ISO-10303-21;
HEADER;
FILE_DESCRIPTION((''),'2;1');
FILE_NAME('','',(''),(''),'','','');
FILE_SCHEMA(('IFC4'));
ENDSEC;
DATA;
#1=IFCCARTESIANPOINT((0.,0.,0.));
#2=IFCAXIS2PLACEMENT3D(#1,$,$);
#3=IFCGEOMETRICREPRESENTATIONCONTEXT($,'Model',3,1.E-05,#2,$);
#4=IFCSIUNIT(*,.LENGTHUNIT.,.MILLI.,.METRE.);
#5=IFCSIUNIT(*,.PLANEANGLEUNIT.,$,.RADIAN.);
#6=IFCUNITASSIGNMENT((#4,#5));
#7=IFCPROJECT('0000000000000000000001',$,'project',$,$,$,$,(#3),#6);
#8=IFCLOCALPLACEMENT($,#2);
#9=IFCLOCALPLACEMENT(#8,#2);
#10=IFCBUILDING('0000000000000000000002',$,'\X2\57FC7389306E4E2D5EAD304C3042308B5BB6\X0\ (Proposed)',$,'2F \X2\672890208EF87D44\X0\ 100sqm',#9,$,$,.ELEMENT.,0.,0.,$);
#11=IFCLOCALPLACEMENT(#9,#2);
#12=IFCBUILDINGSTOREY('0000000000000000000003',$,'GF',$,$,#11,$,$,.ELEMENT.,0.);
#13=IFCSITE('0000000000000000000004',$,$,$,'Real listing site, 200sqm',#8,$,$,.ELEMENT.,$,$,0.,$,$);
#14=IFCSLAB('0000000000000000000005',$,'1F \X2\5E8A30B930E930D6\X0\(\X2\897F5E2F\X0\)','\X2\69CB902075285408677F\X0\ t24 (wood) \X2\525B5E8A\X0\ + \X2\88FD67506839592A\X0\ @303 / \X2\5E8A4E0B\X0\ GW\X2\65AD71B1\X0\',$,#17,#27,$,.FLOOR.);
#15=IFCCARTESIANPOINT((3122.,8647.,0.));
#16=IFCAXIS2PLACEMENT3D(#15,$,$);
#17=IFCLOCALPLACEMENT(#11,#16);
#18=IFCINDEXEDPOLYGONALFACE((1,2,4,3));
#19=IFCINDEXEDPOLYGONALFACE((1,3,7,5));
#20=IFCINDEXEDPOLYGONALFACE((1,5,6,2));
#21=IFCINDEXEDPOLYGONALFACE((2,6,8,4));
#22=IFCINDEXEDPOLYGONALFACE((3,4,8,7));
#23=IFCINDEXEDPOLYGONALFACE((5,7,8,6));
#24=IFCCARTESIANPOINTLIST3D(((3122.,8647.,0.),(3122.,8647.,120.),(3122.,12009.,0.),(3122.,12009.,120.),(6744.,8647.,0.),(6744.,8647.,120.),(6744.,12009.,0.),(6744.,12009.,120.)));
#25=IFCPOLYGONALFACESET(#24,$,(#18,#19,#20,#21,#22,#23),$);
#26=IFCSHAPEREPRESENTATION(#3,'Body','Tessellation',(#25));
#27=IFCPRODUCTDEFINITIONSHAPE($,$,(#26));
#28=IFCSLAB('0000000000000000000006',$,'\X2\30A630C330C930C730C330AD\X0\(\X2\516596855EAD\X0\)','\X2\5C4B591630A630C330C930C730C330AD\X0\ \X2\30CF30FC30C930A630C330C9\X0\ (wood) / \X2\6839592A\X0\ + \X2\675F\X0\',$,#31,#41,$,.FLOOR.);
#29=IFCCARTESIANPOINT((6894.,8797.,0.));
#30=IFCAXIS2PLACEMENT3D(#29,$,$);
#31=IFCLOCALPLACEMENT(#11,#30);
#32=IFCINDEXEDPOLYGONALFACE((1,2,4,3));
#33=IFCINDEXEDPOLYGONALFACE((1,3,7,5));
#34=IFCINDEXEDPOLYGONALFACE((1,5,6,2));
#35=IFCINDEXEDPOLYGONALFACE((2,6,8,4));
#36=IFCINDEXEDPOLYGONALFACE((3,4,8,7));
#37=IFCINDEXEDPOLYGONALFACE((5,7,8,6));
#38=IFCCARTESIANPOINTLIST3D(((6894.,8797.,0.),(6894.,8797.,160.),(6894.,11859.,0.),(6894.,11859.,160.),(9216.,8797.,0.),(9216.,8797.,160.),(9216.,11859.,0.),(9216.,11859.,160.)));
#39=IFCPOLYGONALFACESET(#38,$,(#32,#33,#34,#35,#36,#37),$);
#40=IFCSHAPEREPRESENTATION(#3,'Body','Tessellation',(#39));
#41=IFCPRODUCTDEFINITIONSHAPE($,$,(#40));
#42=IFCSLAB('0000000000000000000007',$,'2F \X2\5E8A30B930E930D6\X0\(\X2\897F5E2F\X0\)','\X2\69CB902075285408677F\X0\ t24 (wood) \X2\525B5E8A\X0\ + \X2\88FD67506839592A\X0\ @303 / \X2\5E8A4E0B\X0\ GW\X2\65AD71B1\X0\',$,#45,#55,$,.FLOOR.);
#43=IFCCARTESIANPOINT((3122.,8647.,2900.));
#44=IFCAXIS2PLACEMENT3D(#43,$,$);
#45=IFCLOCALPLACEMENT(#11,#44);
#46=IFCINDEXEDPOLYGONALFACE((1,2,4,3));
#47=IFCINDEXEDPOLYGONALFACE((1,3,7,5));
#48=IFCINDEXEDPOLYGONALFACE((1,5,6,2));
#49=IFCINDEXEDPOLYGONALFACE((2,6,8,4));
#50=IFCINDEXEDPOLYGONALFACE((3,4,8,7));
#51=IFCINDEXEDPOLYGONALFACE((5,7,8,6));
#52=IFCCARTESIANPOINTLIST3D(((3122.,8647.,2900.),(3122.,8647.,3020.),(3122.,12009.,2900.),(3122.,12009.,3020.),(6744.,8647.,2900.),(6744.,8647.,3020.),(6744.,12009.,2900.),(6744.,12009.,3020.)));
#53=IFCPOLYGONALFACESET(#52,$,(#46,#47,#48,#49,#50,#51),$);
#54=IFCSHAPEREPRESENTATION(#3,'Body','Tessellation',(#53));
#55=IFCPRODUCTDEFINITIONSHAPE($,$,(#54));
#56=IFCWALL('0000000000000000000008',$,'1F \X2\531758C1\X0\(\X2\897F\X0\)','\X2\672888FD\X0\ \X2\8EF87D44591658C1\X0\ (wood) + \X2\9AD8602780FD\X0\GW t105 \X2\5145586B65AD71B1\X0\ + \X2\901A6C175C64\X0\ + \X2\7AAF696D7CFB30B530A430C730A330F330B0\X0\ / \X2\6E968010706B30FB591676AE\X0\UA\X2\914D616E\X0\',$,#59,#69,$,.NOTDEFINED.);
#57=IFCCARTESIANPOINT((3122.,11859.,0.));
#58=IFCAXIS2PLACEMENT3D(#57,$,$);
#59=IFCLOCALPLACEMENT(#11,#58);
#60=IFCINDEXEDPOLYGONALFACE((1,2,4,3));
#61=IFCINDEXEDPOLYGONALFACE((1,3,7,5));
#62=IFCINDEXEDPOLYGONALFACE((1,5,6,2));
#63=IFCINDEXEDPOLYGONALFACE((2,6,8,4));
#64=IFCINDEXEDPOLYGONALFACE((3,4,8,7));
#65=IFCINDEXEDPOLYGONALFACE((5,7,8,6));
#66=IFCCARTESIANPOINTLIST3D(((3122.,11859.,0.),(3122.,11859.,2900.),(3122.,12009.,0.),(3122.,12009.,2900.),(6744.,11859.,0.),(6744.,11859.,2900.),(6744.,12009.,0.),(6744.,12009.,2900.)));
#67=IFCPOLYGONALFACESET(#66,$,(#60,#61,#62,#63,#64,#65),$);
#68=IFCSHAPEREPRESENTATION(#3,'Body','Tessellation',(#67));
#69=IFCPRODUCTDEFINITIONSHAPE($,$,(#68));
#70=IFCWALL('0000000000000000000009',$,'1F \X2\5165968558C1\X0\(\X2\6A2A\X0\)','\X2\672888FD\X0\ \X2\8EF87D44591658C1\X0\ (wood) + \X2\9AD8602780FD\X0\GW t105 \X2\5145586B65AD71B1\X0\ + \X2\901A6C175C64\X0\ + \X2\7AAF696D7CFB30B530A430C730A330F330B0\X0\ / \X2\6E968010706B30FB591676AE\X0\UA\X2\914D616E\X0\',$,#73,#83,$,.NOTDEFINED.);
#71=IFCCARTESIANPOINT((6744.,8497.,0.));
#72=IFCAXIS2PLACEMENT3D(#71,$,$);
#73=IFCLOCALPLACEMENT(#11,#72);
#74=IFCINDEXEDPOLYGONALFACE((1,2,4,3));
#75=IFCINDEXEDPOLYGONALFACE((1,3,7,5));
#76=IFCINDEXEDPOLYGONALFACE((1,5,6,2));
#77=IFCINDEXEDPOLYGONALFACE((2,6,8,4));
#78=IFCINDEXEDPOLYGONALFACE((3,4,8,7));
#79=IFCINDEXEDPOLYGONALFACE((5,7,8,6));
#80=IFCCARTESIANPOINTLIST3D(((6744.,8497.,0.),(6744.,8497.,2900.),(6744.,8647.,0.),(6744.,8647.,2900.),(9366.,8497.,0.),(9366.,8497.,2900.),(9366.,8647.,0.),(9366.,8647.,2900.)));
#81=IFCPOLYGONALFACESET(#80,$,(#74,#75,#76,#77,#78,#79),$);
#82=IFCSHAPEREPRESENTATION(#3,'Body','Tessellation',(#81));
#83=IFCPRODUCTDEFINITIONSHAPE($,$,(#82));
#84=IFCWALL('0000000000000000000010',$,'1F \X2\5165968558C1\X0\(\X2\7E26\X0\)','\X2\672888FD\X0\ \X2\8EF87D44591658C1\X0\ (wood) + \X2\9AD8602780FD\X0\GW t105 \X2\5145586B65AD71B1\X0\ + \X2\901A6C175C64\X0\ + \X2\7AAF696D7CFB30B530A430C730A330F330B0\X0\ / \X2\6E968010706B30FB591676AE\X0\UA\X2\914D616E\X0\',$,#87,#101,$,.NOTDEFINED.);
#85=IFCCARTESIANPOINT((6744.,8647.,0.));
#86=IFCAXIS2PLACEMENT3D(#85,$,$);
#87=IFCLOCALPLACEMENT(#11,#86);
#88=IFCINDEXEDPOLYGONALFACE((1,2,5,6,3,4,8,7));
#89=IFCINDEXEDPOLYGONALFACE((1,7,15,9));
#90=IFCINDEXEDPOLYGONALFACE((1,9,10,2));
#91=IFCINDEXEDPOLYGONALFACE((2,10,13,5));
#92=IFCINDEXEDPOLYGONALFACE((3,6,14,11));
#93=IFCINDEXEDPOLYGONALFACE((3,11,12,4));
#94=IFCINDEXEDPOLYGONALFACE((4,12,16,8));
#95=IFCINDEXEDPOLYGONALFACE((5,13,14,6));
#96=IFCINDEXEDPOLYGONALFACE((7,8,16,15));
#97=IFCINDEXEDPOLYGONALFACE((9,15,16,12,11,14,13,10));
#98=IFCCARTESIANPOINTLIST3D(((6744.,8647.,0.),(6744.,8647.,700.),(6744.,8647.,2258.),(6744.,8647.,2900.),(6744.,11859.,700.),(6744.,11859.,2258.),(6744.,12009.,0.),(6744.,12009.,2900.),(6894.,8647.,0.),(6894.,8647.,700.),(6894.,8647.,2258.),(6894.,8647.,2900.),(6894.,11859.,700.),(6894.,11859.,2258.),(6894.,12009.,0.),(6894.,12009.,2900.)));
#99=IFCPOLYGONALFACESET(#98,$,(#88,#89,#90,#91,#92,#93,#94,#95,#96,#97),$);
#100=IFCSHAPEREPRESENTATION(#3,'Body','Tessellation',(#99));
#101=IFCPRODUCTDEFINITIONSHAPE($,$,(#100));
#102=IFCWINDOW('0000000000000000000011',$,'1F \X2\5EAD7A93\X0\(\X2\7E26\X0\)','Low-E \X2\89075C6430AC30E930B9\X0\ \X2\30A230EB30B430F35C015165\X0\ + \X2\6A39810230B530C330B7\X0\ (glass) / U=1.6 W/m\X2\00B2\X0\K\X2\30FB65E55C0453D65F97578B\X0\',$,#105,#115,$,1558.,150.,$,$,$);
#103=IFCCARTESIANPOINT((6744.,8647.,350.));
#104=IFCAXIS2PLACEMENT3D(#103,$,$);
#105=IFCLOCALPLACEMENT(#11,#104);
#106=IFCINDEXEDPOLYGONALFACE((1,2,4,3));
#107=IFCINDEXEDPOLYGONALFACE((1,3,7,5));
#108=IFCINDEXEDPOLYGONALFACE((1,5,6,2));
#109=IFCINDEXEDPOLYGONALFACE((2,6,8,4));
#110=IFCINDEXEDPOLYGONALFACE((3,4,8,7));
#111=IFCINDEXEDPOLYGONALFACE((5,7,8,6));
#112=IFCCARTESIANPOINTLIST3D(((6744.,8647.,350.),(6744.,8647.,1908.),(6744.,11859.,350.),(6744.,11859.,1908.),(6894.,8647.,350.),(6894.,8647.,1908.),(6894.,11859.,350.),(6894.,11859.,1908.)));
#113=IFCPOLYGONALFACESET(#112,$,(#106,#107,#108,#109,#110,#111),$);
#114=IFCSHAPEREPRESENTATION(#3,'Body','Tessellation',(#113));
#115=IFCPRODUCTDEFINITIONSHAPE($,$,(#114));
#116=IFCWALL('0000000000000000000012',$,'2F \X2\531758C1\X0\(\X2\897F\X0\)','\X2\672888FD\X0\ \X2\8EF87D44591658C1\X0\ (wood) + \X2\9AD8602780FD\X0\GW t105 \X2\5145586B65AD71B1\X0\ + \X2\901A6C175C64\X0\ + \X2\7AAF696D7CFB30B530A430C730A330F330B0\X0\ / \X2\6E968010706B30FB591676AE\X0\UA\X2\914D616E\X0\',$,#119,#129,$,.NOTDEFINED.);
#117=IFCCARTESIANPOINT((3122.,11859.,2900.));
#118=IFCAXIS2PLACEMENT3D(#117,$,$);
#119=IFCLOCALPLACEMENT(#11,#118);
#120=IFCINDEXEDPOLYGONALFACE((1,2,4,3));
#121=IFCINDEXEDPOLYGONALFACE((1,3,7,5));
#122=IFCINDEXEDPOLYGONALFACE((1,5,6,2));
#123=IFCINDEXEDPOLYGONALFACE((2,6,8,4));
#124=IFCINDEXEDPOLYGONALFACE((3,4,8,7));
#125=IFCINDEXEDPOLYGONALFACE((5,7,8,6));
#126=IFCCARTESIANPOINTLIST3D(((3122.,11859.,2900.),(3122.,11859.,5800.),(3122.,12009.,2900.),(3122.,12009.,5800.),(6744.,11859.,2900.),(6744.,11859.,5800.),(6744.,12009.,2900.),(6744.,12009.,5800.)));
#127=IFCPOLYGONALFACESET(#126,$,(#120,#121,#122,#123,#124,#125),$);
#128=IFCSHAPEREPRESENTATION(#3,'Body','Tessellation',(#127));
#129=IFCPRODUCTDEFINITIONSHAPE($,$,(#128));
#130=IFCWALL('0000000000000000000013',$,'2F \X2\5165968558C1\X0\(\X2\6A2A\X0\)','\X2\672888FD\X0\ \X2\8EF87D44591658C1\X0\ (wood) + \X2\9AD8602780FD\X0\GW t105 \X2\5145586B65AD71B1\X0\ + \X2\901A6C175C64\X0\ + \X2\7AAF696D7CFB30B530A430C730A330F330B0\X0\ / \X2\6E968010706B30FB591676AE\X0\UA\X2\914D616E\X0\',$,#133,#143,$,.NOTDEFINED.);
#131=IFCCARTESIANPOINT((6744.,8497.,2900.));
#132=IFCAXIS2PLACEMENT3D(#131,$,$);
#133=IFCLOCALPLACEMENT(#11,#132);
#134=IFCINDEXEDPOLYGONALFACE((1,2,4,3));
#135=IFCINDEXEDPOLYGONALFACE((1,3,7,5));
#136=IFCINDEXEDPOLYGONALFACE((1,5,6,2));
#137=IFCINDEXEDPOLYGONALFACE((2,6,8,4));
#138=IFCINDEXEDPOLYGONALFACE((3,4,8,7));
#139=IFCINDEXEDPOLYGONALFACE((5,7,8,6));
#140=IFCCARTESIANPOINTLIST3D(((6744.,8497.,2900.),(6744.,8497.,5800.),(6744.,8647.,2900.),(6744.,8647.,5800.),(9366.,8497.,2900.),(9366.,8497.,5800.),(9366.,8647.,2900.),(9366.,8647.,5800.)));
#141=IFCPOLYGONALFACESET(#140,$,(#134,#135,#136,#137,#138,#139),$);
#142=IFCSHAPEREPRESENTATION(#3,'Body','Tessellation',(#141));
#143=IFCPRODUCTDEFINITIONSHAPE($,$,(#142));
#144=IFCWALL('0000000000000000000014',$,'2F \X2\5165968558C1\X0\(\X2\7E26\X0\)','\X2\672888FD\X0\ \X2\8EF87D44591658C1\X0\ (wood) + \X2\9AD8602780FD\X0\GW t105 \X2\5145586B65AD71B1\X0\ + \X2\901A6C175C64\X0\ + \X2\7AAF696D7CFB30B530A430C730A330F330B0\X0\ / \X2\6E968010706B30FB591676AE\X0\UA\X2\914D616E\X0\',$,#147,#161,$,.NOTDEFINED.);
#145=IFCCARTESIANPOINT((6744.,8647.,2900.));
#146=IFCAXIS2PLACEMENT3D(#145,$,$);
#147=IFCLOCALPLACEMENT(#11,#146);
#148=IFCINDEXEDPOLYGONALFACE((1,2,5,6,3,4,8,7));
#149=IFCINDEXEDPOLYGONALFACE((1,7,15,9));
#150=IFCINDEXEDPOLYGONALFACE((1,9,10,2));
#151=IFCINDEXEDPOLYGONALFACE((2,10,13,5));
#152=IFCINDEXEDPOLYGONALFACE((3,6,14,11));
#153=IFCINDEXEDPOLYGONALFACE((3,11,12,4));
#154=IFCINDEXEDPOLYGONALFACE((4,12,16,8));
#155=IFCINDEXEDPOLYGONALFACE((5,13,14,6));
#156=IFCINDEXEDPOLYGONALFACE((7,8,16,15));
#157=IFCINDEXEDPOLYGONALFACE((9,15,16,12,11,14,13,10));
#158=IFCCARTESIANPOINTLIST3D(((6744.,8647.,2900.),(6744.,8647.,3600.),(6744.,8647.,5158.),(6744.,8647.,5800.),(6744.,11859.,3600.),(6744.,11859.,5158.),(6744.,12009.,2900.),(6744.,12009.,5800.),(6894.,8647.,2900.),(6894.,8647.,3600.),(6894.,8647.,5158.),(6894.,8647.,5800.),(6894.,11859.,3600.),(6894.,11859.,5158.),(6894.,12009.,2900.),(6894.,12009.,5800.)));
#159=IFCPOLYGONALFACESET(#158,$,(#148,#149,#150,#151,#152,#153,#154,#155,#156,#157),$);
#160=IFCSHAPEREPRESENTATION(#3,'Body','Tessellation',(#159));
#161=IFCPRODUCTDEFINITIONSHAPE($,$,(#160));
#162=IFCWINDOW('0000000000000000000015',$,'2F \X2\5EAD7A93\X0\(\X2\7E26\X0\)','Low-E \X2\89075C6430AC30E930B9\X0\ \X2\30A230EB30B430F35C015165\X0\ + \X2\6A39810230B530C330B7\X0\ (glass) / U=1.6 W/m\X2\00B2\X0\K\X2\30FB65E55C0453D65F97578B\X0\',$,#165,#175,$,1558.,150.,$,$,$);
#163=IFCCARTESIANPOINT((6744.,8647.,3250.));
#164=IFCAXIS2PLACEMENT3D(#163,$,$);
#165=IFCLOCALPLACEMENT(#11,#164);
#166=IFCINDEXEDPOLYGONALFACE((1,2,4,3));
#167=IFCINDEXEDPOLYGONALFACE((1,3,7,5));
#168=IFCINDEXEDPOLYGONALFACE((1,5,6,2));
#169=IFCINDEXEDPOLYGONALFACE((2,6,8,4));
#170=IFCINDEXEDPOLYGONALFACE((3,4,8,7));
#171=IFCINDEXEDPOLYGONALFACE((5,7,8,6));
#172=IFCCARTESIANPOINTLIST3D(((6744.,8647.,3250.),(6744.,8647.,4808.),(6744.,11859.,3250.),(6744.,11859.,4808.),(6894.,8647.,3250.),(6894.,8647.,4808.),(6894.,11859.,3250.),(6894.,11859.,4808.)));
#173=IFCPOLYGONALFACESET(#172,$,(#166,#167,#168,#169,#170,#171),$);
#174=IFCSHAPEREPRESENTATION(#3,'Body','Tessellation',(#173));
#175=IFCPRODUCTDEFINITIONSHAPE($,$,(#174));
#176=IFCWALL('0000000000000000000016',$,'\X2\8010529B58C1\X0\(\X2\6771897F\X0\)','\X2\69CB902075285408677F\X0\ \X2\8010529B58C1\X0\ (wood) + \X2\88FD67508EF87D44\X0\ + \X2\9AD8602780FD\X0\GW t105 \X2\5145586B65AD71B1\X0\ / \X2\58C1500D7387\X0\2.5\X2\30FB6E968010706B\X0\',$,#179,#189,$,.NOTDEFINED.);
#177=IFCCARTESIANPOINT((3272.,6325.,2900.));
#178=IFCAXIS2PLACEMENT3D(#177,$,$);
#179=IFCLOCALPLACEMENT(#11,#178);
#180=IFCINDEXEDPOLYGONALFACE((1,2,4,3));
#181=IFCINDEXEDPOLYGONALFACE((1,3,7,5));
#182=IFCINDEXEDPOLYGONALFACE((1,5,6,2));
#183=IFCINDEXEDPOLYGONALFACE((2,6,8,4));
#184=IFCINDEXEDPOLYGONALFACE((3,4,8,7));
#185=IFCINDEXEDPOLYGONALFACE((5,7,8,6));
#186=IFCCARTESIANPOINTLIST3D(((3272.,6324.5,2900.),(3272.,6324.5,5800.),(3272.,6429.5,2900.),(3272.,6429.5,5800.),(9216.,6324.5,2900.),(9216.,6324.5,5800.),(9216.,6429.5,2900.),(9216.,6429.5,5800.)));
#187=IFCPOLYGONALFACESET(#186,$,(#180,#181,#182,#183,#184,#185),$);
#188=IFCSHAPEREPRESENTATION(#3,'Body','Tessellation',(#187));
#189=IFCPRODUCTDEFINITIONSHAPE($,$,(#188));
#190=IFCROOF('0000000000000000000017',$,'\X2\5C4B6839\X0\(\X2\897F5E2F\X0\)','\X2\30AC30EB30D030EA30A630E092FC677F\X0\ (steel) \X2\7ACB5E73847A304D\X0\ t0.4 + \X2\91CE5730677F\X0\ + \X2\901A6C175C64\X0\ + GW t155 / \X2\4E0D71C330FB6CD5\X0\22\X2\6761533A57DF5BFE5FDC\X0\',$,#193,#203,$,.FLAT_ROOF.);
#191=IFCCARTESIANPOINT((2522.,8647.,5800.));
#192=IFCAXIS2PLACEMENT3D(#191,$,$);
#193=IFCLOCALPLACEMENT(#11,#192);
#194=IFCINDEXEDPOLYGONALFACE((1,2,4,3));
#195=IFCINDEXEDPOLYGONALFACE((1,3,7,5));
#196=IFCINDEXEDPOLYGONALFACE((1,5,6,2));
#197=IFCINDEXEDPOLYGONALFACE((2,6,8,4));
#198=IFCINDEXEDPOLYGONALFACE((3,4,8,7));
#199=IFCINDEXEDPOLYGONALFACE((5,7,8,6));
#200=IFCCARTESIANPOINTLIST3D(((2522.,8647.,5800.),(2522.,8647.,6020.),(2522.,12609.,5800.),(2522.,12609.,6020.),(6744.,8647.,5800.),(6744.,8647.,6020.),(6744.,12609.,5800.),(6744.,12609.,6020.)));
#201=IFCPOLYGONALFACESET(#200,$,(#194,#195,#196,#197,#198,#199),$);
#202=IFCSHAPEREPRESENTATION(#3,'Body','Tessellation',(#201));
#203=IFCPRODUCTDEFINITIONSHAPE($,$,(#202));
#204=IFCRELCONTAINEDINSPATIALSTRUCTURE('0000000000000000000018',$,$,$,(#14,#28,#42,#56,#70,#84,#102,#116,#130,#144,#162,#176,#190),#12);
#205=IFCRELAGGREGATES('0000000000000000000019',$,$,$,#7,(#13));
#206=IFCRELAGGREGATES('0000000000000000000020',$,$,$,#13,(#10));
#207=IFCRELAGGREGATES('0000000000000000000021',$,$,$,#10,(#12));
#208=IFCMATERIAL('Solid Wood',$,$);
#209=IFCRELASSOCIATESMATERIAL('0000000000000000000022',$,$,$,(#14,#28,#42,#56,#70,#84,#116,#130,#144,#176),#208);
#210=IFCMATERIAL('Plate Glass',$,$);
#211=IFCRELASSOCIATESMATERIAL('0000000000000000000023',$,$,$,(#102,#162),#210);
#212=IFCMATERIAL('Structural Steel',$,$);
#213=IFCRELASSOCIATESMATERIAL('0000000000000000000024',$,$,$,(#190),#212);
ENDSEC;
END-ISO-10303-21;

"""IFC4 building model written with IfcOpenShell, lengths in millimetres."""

from ifc_helpers import new_model, si_unit, frame, frame_2d, origin, place, context, project, spatial, rectangle, extrude, material, element, fill, save


model = new_model("IFC4")

# Units and contexts
model_context = context("Model", 3, precision=1e-05, world=origin())
ifc_project = project(units=[si_unit("LENGTHUNIT", "METRE", prefix="MILLI"), si_unit("PLANEANGLEUNIT", "RADIAN")], contexts=[model_context])

# Site, building, storey
site_placement = place(None, origin())
site = spatial("IfcSite", under=ifc_project, at=site_placement, ObjectType="Real listing site, 200sqm", CompositionType="ELEMENT", RefElevation=0.0)
building_placement = place(site_placement, origin())
building = spatial("IfcBuilding", under=site, at=building_placement, Name="埼玉の中庭がある家 (Proposed)", ObjectType="2F 木造軸組 100sqm", CompositionType="ELEMENT", ElevationOfRefHeight=0.0, ElevationOfTerrain=0.0)
storey_placement = place(building_placement, origin())
storey = spatial("IfcBuildingStorey", under=building, at=storey_placement, Name="GF", CompositionType="ELEMENT", Elevation=0.0)

# Slabs
ifc_material_1 = material(Name="Solid Wood")
slab_1_placement = place(storey_placement, frame((3122.0, 8647.0, 0.0)))
element("IfcSlab", 1, at=slab_1_placement, inside=storey, material=ifc_material_1, Name="1F 床スラブ(西帯)", Description="構造用合板 t24 (wood) 剛床 + 製材根太 @303 / 床下 GW断熱", PredefinedType="FLOOR", context=model_context, shape_type="SweptSolid", body=[
    extrude(rectangle(XDim=3622.0, YDim=3362.0, at=frame_2d((1811.0, 1681.0))), frame((3122.0, 8647.0, 0.0)), (0.0, 0.0, 1.0), 120.0),
])
slab_2_placement = place(storey_placement, frame((6894.0, 8797.0, 0.0)))
element("IfcSlab", 2, at=slab_2_placement, inside=storey, material=ifc_material_1, Name="ウッドデッキ(入隅庭)", Description="屋外ウッドデッキ ハードウッド (wood) / 根太 + 束", PredefinedType="FLOOR", context=model_context, shape_type="SweptSolid", body=[
    extrude(rectangle(XDim=2322.0, YDim=3062.0, at=frame_2d((1161.0, 1531.0))), frame((6894.0, 8797.0, 0.0)), (0.0, 0.0, 1.0), 160.0),
])
slab_3_placement = place(storey_placement, frame((3122.0, 8647.0, 2900.0)))
element("IfcSlab", 3, at=slab_3_placement, inside=storey, material=ifc_material_1, Name="2F 床スラブ(西帯)", Description="構造用合板 t24 (wood) 剛床 + 製材根太 @303 / 床下 GW断熱", PredefinedType="FLOOR", context=model_context, shape_type="SweptSolid", body=[
    extrude(rectangle(XDim=3622.0, YDim=3362.0, at=frame_2d((1811.0, 1681.0))), frame((3122.0, 8647.0, 2900.0)), (0.0, 0.0, 1.0), 120.0),
])

# Walls
wall_1_placement = place(storey_placement, frame((3122.0, 11859.0, 0.0)))
element("IfcWall", 4, at=wall_1_placement, inside=storey, material=ifc_material_1, Name="1F 北壁(西)", Description="木製 軸組外壁 (wood) + 高性能GW t105 充填断熱 + 通気層 + 窯業系サイディング / 準耐火・外皮UA配慮", PredefinedType="NOTDEFINED", context=model_context, shape_type="SweptSolid", body=[
    extrude(rectangle(XDim=3622.0, YDim=150.0, at=frame_2d((1811.0, 75.0))), frame((3122.0, 11859.0, 0.0)), (0.0, 0.0, 1.0), 2900.0),
])
wall_2_placement = place(storey_placement, frame((6744.0, 8497.0, 0.0)))
element("IfcWall", 5, at=wall_2_placement, inside=storey, material=ifc_material_1, Name="1F 入隅壁(横)", Description="木製 軸組外壁 (wood) + 高性能GW t105 充填断熱 + 通気層 + 窯業系サイディング / 準耐火・外皮UA配慮", PredefinedType="NOTDEFINED", context=model_context, shape_type="SweptSolid", body=[
    extrude(rectangle(XDim=2622.0, YDim=150.0, at=frame_2d((1311.0, 75.0))), frame((6744.0, 8497.0, 0.0)), (0.0, 0.0, 1.0), 2900.0),
])

# Wall, opening, window
wall_3_placement = place(storey_placement, frame((6744.0, 8647.0, 0.0)))
wall_3 = element("IfcWall", 6, at=wall_3_placement, inside=storey, material=ifc_material_1, Name="1F 入隅壁(縦)", Description="木製 軸組外壁 (wood) + 高性能GW t105 充填断熱 + 通気層 + 窯業系サイディング / 準耐火・外皮UA配慮", PredefinedType="NOTDEFINED", context=model_context, shape_type="SweptSolid", body=[
    extrude(rectangle(XDim=150.0, YDim=3362.0, at=frame_2d((75.0, 1681.0))), frame((6744.0, 8647.0, 0.0)), (0.0, 0.0, 1.0), 2900.0),
])
opening_1_placement = place(storey_placement, frame((6744.0, 8647.0, 350.0)))
opening_1 = element("IfcOpeningElement", 7, at=opening_1_placement, cuts=wall_3, PredefinedType="NOTDEFINED", context=model_context, shape_type="SweptSolid", body=[
    extrude(rectangle(XDim=150.0, YDim=3212.0, at=frame_2d((75.0, 1606.0))), frame((6744.0, 8647.0, 350.0)), (0.0, 0.0, 1.0), 1558.0),
])
ifc_material_2 = material(Name="Plate Glass")
window_1_placement = place(storey_placement, frame((6744.0, 8647.0, 350.0)))
window_1 = element("IfcWindow", 8, at=window_1_placement, inside=storey, material=ifc_material_2, Name="1F 庭窓(縦)", Description="Low-E 複層ガラス アルゴン封入 + 樹脂サッシ (glass) / U=1.6 W/m²K・日射取得型", OverallHeight=1558.0, OverallWidth=150.0, context=model_context, shape_type="SweptSolid", body=[
    extrude(rectangle(XDim=150.0, YDim=3212.0, at=frame_2d((75.0, 1606.0))), frame((6744.0, 8647.0, 350.0)), (0.0, 0.0, 1.0), 1558.0),
])
fill(opening_1, window_1)

# Walls
wall_4_placement = place(storey_placement, frame((3122.0, 11859.0, 2900.0)))
element("IfcWall", 9, at=wall_4_placement, inside=storey, material=ifc_material_1, Name="2F 北壁(西)", Description="木製 軸組外壁 (wood) + 高性能GW t105 充填断熱 + 通気層 + 窯業系サイディング / 準耐火・外皮UA配慮", PredefinedType="NOTDEFINED", context=model_context, shape_type="SweptSolid", body=[
    extrude(rectangle(XDim=3622.0, YDim=150.0, at=frame_2d((1811.0, 75.0))), frame((3122.0, 11859.0, 2900.0)), (0.0, 0.0, 1.0), 2900.0),
])
wall_5_placement = place(storey_placement, frame((6744.0, 8497.0, 2900.0)))
element("IfcWall", 10, at=wall_5_placement, inside=storey, material=ifc_material_1, Name="2F 入隅壁(横)", Description="木製 軸組外壁 (wood) + 高性能GW t105 充填断熱 + 通気層 + 窯業系サイディング / 準耐火・外皮UA配慮", PredefinedType="NOTDEFINED", context=model_context, shape_type="SweptSolid", body=[
    extrude(rectangle(XDim=2622.0, YDim=150.0, at=frame_2d((1311.0, 75.0))), frame((6744.0, 8497.0, 2900.0)), (0.0, 0.0, 1.0), 2900.0),
])

# Wall, opening, window
wall_6_placement = place(storey_placement, frame((6744.0, 8647.0, 2900.0)))
wall_6 = element("IfcWall", 11, at=wall_6_placement, inside=storey, material=ifc_material_1, Name="2F 入隅壁(縦)", Description="木製 軸組外壁 (wood) + 高性能GW t105 充填断熱 + 通気層 + 窯業系サイディング / 準耐火・外皮UA配慮", PredefinedType="NOTDEFINED", context=model_context, shape_type="SweptSolid", body=[
    extrude(rectangle(XDim=150.0, YDim=3362.0, at=frame_2d((75.0, 1681.0))), frame((6744.0, 8647.0, 2900.0)), (0.0, 0.0, 1.0), 2900.0),
])
opening_2_placement = place(storey_placement, frame((6744.0, 8647.0, 3250.0)))
opening_2 = element("IfcOpeningElement", 12, at=opening_2_placement, cuts=wall_6, PredefinedType="NOTDEFINED", context=model_context, shape_type="SweptSolid", body=[
    extrude(rectangle(XDim=150.0, YDim=3212.0, at=frame_2d((75.0, 1606.0))), frame((6744.0, 8647.0, 3250.0)), (0.0, 0.0, 1.0), 1558.0),
])
window_2_placement = place(storey_placement, frame((6744.0, 8647.0, 3250.0)))
window_2 = element("IfcWindow", 13, at=window_2_placement, inside=storey, material=ifc_material_2, Name="2F 庭窓(縦)", Description="Low-E 複層ガラス アルゴン封入 + 樹脂サッシ (glass) / U=1.6 W/m²K・日射取得型", OverallHeight=1558.0, OverallWidth=150.0, context=model_context, shape_type="SweptSolid", body=[
    extrude(rectangle(XDim=150.0, YDim=3212.0, at=frame_2d((75.0, 1606.0))), frame((6744.0, 8647.0, 3250.0)), (0.0, 0.0, 1.0), 1558.0),
])
fill(opening_2, window_2)

# Wall
wall_7_placement = place(storey_placement, frame((3272.0, 6325.0, 2900.0)))
element("IfcWall", 14, at=wall_7_placement, inside=storey, material=ifc_material_1, Name="耐力壁(東西)", Description="構造用合板 耐力壁 (wood) + 製材軸組 + 高性能GW t105 充填断熱 / 壁倍率2.5・準耐火", PredefinedType="NOTDEFINED", context=model_context, shape_type="SweptSolid", body=[
    extrude(rectangle(XDim=5944.0, YDim=105.0, at=frame_2d((2972.0, 52.0))), frame((3272.0, 6325.0, 2900.0)), (0.0, 0.0, 1.0), 2900.0),
])

# Roof
ifc_material_3 = material(Name="Structural Steel")
for number, where, name in (
    (15, (2522.0, 8647.0, 5800.0), "屋根(西帯)"),
):
    element("IfcRoof", number, at=place(storey_placement, frame(where)), inside=storey, material=ifc_material_3, Name=name, Description="ガルバリウム鋼板 (steel) 立平葺き t0.4 + 野地板 + 通気層 + GW t155 / 不燃・法22条区域対応", PredefinedType="FLAT_ROOF", context=model_context, shape_type="SweptSolid", body=[
        extrude(rectangle(XDim=4222.0, YDim=3962.0, at=frame_2d((2111.0, 1981.0))), frame((2522.0, 8647.0, 5800.0)), (0.0, 0.0, 1.0), 220.0),
    ])

save(model, "model.ifc")
